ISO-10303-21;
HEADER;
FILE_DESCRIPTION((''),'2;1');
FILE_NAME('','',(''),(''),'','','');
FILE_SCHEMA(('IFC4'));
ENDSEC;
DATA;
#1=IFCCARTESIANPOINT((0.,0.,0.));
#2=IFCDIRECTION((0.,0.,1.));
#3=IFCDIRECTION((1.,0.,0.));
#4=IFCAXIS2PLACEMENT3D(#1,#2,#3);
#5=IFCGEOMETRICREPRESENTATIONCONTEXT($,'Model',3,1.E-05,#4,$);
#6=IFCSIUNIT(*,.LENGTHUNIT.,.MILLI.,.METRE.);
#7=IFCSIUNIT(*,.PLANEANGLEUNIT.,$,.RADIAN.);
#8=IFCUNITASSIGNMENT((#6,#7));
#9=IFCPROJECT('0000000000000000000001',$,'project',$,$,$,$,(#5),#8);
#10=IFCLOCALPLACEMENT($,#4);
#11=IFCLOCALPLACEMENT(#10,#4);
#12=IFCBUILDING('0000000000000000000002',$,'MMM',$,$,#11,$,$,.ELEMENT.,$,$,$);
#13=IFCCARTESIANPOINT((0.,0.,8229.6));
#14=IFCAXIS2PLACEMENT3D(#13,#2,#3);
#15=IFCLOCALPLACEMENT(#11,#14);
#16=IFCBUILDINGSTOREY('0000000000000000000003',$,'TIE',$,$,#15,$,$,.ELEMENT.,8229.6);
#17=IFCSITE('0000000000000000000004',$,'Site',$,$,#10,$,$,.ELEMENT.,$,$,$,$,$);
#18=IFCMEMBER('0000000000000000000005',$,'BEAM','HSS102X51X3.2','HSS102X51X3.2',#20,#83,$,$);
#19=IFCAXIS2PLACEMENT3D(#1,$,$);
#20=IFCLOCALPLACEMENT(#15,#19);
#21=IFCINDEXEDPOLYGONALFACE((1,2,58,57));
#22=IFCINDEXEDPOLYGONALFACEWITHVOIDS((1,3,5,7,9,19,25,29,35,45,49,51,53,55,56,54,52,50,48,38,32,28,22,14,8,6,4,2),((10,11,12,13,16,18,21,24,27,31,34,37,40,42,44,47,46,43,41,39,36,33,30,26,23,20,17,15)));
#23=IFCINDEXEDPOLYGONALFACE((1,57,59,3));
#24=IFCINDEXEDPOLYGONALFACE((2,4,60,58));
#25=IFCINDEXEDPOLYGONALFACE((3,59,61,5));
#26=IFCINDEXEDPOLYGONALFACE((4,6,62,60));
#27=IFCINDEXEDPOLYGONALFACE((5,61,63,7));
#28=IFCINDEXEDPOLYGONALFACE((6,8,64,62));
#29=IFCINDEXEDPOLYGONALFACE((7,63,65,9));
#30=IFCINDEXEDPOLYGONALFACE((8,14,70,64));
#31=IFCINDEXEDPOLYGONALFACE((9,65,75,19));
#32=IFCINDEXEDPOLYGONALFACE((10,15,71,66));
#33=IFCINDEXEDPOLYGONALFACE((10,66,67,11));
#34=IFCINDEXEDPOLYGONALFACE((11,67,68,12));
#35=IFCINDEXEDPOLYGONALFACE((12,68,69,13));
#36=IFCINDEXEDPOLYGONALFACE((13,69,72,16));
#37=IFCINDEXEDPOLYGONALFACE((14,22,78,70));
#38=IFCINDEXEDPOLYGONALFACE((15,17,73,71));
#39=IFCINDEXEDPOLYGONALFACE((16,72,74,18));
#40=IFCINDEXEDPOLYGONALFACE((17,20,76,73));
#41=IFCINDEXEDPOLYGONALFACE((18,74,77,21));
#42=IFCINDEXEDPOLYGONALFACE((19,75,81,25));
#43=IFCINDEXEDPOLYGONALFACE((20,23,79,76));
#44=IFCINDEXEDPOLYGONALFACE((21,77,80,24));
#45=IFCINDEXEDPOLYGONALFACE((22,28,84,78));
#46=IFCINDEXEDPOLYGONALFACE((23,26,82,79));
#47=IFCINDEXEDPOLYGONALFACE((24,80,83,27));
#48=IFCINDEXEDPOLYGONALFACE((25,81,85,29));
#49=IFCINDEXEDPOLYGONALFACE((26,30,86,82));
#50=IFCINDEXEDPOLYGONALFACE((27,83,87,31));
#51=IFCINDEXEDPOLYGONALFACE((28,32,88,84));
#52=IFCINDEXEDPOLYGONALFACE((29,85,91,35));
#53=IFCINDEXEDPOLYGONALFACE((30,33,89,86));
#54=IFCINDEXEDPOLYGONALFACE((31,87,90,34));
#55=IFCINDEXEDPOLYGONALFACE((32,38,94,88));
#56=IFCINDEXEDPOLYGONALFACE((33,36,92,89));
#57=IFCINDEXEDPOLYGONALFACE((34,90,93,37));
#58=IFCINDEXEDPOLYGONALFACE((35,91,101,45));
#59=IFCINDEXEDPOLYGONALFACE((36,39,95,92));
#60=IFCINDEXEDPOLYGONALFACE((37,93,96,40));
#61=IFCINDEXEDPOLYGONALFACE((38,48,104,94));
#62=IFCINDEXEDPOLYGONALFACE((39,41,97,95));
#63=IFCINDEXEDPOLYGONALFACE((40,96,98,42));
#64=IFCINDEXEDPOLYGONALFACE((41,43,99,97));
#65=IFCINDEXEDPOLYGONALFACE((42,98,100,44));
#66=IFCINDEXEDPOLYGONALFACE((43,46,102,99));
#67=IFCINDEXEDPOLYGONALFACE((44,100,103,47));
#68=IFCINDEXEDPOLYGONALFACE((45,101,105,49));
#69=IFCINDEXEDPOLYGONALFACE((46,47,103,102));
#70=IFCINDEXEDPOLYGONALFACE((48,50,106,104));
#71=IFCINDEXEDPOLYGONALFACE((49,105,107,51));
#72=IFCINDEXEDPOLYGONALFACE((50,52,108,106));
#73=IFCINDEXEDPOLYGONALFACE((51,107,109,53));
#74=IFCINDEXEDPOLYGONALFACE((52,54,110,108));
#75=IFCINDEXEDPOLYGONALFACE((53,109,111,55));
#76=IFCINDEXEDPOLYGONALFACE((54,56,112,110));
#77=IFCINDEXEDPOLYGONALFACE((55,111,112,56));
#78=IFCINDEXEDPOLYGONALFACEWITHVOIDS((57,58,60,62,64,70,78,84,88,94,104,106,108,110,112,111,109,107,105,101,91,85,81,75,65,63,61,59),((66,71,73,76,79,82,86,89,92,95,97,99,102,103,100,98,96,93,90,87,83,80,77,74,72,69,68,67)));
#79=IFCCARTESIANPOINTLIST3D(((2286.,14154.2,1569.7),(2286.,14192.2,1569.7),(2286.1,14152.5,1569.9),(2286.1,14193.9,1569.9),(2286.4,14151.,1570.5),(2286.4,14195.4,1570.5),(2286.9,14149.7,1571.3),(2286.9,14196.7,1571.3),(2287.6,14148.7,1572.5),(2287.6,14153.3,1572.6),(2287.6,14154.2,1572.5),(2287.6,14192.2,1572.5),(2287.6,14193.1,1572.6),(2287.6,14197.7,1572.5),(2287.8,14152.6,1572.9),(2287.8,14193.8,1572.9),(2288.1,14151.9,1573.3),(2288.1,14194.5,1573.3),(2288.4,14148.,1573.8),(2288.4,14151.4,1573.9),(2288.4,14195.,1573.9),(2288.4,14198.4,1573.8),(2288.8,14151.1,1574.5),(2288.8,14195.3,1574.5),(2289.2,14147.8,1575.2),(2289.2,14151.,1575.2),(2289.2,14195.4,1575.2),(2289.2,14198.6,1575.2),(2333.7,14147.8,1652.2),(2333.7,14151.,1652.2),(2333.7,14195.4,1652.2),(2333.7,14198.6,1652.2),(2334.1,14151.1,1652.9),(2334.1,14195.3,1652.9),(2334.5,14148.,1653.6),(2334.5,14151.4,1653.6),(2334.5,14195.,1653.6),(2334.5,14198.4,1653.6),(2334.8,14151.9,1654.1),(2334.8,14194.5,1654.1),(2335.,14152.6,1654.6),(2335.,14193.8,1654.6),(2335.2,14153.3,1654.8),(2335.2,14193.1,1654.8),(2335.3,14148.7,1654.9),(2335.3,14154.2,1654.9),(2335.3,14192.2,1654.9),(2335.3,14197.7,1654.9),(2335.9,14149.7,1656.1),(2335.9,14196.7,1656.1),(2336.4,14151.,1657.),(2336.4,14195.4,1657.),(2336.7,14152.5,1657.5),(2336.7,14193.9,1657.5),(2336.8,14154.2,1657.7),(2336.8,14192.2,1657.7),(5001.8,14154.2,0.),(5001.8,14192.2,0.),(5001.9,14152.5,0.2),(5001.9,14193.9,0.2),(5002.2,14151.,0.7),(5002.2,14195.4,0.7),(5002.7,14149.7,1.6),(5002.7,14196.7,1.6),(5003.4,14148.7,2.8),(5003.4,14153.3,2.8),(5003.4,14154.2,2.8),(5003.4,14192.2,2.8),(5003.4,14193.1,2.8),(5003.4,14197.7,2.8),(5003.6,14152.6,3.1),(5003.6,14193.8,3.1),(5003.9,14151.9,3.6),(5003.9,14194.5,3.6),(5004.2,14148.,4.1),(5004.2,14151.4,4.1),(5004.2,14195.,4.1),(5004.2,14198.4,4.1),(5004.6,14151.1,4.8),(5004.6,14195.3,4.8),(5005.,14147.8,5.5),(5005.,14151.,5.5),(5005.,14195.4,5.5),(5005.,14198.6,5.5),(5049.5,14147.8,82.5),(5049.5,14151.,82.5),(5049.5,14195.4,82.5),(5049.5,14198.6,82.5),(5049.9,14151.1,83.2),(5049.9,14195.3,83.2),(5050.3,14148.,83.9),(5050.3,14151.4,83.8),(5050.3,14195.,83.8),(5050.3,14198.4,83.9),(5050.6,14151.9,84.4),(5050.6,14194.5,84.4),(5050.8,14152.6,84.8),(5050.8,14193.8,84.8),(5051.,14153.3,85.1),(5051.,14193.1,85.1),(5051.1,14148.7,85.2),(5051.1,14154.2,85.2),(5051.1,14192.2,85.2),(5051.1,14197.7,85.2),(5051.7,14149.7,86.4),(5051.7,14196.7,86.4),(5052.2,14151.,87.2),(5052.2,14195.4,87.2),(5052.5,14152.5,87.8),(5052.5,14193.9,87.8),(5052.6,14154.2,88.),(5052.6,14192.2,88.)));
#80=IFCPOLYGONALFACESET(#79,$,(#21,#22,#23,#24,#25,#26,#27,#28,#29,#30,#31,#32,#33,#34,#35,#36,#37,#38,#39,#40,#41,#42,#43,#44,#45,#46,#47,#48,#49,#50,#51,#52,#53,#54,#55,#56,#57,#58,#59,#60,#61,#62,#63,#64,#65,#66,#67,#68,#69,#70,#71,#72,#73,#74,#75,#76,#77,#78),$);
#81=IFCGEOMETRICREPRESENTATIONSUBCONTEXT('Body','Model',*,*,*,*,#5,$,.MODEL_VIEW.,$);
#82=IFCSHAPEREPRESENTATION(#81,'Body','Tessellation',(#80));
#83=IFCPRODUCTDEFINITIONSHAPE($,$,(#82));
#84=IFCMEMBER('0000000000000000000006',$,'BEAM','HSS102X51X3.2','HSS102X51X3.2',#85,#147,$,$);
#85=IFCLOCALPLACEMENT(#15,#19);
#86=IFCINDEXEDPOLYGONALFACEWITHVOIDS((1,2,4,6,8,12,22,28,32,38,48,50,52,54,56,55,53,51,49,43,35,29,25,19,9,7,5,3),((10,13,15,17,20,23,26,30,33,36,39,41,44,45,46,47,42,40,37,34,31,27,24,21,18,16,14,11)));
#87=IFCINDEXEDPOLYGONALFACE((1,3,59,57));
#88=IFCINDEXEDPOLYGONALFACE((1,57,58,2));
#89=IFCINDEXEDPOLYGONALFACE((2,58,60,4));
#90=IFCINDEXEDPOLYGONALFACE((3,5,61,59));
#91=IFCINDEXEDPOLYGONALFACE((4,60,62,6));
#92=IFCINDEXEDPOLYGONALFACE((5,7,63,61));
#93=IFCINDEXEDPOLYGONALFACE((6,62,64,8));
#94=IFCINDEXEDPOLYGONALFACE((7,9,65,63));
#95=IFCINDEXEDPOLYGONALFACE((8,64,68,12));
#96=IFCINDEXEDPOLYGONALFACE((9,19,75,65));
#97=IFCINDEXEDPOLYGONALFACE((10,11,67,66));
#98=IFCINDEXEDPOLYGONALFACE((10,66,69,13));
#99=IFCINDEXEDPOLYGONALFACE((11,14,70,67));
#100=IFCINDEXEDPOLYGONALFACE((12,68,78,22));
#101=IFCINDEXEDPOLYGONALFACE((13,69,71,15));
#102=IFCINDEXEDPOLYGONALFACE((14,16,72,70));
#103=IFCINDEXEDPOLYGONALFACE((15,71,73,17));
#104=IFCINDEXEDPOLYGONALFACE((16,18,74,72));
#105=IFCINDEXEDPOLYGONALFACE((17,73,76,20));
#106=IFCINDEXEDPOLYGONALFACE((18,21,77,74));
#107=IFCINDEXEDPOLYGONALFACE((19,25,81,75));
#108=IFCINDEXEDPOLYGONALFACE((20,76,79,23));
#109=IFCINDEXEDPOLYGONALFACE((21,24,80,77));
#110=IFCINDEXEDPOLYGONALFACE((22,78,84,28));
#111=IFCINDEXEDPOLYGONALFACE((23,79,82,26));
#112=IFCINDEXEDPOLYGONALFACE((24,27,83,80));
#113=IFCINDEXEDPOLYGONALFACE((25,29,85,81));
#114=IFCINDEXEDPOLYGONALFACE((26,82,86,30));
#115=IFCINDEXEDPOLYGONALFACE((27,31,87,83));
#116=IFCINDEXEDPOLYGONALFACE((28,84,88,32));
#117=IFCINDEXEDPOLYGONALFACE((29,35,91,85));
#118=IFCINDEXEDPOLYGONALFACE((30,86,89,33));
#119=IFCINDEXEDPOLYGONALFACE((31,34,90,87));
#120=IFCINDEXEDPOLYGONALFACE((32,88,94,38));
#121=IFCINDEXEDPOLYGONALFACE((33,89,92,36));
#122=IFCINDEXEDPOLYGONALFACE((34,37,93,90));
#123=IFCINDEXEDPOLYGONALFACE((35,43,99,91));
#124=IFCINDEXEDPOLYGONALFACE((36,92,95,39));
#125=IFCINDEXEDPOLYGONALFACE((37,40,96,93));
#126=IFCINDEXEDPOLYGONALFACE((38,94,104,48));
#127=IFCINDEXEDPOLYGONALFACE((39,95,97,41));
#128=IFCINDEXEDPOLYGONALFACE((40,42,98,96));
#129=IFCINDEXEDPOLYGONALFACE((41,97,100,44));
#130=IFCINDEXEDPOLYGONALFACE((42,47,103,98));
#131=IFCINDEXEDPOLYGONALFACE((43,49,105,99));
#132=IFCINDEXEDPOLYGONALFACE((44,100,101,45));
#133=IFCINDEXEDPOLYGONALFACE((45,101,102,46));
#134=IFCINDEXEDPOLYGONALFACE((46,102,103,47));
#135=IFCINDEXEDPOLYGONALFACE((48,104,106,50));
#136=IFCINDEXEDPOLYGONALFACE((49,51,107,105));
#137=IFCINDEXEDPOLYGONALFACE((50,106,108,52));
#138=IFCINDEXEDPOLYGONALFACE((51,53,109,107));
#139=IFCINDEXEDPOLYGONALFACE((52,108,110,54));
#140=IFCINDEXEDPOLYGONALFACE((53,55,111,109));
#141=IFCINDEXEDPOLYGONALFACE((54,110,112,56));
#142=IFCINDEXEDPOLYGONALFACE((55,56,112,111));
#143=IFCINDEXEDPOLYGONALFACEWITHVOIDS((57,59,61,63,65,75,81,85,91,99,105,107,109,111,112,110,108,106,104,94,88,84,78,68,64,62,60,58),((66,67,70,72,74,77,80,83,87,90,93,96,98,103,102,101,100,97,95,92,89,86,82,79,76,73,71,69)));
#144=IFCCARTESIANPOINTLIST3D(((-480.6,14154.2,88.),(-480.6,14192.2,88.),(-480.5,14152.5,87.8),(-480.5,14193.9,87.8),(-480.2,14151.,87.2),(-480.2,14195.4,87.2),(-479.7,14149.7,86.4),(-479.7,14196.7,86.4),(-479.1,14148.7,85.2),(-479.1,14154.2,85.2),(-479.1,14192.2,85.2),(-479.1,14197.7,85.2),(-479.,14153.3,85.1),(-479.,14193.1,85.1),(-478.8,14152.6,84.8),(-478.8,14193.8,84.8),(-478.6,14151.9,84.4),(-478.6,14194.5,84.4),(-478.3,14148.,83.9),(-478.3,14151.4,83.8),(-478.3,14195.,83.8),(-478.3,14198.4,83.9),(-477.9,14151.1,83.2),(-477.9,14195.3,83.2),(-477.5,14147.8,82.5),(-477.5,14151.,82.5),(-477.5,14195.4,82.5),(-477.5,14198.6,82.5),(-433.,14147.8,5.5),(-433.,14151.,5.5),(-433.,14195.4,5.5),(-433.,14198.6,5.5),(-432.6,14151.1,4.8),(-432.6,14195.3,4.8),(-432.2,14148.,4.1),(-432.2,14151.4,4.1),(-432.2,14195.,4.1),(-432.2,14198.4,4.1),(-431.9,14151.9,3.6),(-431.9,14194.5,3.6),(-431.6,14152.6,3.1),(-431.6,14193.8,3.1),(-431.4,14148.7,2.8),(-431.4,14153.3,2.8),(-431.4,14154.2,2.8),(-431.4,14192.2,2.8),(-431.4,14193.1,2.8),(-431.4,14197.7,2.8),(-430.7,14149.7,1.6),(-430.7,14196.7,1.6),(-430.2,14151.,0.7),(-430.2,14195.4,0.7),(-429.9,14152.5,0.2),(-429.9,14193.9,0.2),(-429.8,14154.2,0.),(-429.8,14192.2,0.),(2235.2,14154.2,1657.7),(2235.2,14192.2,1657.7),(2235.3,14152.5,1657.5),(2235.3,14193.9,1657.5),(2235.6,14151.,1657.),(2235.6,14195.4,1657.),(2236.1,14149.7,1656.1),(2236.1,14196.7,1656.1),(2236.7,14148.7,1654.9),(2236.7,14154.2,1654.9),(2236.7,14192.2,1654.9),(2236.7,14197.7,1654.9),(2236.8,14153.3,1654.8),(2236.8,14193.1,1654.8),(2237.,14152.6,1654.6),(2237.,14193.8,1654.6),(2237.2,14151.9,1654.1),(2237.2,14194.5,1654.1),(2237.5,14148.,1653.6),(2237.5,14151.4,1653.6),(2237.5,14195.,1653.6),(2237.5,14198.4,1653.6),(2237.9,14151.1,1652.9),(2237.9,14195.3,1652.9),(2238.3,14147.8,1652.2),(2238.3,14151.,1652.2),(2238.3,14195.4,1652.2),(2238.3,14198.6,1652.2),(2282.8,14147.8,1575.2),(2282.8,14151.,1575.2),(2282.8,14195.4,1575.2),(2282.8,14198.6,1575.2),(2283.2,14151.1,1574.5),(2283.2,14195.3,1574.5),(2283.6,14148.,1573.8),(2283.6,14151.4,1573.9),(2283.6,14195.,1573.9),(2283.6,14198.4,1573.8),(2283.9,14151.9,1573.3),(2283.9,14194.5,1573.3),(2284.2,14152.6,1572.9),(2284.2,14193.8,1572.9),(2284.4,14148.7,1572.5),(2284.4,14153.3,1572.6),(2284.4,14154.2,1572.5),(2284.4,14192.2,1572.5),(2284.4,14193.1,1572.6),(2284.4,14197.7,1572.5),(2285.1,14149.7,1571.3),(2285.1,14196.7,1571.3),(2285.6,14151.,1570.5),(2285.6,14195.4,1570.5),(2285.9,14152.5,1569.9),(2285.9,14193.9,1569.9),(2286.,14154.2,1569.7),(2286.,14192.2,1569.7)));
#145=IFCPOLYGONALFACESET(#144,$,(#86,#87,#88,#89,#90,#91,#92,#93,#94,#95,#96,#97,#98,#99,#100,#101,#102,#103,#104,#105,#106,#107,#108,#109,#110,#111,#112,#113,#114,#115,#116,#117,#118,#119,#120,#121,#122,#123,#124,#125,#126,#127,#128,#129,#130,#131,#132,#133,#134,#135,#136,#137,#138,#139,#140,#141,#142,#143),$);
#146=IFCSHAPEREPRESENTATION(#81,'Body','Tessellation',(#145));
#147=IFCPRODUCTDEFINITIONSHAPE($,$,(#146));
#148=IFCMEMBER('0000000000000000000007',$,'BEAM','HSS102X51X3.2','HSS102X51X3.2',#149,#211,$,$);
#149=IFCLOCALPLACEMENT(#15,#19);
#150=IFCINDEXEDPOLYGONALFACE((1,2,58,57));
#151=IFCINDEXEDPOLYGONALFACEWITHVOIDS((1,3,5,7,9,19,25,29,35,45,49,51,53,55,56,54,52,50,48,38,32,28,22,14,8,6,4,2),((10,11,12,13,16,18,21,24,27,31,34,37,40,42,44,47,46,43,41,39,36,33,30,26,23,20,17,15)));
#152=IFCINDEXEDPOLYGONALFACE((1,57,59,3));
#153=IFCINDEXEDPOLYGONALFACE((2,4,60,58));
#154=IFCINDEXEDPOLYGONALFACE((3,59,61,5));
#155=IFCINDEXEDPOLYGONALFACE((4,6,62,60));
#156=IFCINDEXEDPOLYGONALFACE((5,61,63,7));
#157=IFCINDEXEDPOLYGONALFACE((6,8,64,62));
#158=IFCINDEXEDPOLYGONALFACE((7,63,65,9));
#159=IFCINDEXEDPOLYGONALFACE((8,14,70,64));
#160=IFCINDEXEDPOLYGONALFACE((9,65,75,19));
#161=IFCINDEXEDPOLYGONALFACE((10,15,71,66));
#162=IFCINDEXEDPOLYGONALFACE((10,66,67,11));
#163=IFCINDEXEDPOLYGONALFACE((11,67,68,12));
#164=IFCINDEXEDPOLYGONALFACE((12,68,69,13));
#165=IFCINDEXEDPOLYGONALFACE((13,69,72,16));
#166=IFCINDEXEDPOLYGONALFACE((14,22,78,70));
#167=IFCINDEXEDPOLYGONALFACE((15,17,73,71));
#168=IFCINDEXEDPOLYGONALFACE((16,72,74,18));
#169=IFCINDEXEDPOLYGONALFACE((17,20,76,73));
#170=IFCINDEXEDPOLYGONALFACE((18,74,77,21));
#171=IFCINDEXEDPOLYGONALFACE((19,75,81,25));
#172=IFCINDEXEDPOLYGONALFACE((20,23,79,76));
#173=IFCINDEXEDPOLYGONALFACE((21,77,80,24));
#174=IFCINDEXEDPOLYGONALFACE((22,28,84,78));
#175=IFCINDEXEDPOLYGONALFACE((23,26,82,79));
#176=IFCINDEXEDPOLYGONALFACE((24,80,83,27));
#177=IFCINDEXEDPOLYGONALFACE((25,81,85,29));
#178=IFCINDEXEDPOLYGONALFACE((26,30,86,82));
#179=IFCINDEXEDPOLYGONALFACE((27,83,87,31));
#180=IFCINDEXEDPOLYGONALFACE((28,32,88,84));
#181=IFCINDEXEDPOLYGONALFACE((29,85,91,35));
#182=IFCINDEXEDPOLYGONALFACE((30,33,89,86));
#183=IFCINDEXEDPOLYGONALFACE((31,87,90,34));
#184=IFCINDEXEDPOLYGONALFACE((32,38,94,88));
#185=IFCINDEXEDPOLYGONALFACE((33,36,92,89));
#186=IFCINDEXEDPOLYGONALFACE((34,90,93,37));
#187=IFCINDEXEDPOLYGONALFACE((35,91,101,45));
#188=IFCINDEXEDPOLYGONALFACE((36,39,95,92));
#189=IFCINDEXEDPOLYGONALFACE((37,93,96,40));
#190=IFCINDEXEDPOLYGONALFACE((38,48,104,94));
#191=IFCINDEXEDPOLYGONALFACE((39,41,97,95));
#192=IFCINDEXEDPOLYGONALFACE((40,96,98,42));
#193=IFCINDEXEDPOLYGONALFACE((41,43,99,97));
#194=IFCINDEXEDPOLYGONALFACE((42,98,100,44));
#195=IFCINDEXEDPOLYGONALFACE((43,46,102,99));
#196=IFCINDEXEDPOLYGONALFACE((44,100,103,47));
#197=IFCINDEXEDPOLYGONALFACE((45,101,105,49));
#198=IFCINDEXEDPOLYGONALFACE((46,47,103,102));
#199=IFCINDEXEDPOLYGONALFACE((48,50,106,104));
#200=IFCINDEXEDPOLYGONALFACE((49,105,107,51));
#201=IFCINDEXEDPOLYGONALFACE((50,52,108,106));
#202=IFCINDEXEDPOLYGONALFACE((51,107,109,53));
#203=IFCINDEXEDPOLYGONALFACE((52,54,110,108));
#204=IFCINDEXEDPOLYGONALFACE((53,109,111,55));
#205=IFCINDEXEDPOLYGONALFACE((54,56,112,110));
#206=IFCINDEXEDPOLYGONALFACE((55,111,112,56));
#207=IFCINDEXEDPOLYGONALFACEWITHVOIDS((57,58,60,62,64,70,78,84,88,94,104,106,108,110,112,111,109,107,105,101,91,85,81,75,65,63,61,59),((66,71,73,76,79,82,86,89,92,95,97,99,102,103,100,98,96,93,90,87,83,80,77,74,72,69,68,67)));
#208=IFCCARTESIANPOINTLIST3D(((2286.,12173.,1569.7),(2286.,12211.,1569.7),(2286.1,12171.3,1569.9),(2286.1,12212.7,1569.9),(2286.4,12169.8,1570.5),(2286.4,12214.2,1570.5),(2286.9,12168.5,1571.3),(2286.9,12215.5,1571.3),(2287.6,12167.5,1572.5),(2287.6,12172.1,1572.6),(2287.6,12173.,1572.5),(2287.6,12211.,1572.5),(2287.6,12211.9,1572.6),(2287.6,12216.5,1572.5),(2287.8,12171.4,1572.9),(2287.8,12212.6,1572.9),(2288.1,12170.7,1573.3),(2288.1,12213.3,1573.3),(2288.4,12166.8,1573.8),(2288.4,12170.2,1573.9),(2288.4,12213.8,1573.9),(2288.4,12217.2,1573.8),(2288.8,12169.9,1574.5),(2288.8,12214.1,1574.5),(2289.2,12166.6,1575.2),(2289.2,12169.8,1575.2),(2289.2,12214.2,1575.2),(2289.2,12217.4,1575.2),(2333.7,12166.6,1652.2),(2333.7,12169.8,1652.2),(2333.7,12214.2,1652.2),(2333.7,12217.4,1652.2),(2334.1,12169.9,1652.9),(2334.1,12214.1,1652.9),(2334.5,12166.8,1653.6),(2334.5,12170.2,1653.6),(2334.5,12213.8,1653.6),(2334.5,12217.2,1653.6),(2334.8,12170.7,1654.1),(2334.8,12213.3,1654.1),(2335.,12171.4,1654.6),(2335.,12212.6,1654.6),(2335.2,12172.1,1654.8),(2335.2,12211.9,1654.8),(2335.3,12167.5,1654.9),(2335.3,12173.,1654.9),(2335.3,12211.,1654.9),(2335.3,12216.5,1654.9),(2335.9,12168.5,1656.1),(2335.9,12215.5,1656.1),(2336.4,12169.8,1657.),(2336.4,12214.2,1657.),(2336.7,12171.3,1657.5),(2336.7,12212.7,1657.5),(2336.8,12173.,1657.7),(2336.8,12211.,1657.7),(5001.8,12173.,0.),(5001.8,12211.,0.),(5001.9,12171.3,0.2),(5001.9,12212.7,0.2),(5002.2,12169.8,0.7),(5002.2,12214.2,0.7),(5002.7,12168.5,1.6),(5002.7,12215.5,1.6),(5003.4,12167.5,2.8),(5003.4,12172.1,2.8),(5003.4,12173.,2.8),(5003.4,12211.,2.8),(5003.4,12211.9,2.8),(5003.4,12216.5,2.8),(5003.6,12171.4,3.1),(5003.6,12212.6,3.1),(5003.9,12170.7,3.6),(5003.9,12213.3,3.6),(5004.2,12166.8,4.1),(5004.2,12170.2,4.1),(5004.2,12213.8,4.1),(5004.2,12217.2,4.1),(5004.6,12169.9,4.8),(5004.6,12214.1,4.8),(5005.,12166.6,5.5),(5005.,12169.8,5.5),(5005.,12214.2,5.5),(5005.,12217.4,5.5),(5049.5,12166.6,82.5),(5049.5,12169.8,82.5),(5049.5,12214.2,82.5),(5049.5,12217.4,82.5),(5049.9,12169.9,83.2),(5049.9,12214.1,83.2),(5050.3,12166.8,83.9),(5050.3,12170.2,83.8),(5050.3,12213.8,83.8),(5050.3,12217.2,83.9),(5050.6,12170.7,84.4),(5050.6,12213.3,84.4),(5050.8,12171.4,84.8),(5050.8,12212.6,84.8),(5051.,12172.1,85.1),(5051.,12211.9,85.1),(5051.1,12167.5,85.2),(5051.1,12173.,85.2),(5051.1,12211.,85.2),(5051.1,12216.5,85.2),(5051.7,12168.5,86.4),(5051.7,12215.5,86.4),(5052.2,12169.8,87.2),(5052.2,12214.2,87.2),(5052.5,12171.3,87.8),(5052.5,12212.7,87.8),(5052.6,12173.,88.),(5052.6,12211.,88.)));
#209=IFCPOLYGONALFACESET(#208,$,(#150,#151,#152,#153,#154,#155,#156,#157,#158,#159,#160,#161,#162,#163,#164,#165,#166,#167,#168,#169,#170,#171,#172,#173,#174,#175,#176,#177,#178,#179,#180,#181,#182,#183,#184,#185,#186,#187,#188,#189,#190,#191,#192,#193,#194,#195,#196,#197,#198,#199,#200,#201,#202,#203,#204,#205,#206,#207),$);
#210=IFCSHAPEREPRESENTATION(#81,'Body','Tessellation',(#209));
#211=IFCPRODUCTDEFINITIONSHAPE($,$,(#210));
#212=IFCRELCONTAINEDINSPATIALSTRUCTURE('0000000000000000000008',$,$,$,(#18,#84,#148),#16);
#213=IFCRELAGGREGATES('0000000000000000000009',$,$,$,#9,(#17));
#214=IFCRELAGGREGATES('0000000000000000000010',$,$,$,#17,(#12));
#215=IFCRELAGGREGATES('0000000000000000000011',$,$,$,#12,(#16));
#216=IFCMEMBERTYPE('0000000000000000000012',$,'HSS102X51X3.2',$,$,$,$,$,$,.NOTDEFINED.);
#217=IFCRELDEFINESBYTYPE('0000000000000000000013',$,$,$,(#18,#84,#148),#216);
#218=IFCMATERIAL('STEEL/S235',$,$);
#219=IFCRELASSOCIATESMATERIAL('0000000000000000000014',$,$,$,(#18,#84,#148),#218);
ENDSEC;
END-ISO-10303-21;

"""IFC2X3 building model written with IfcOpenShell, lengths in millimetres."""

from ifc_helpers import new_model, si_unit, frame, origin_with_axes, origin_2d_with_axis, place, context, subcontext, project, spatial, hollow_rectangle, extrude, material, type_object, element, save


model = new_model("IFC2X3")

# Units and contexts
model_context = context("Model", 3, precision=1e-05, world=origin_with_axes())
body_context = subcontext(model_context, "Body", "Model", "MODEL_VIEW")
ifc_project = project(units=[si_unit("LENGTHUNIT", "METRE", prefix="MILLI"), si_unit("PLANEANGLEUNIT", "RADIAN")], contexts=[model_context])

# Site, building, storey
site_placement = place(None, origin_with_axes())
site = spatial("IfcSite", under=ifc_project, at=site_placement, Name="Site", CompositionType="ELEMENT")
building_placement = place(site_placement, origin_with_axes())
building = spatial("IfcBuilding", under=site, at=building_placement, Name="MMM", CompositionType="ELEMENT")
storey_placement = place(building_placement, frame((0.0, 0.0, 8229.6), z_axis=(0.0, 0.0, 1.0), x_axis=(1.0, 0.0, 0.0)))
storey = spatial("IfcBuildingStorey", under=building, at=storey_placement, Name="TIE", CompositionType="ELEMENT", Elevation=8229.6)

# Shared definitions
ifc_material = material(Name="STEEL/S235")

# Members
member_type_1 = type_object("IfcMemberType", Name="HSS102X51X3.2", PredefinedType="NOTDEFINED")
for number, where, z_axis, x_axis, name in (
    (1, (2311.4, 14173.2, 1613.7), (0.500422, 0.0, 0.865782), (0.865782, 0.0, -0.500422), "BEAM"),
    (2, (2260.6, 14173.2, 1613.7), (-0.500422, 0.0, 0.865782), (-0.865782, 0.0, -0.500422), "BEAM"),
    (3, (2311.4, 12192.0, 1613.7), (0.500422, 0.0, 0.865782), (0.865782, 0.0, -0.500422), "BEAM"),
):
    element("IfcMember", number, at=place(storey_placement, frame(where, z_axis=z_axis, x_axis=x_axis)), inside=storey, type_object=member_type_1, material=ifc_material, Name=name, Description="HSS102X51X3.2", ObjectType="HSS102X51X3.2", context=body_context, shape_type="SweptSolid", body=[
        extrude(hollow_rectangle(XDim=50.8, YDim=101.6, WallThickness=3.2, InnerFilletRadius=3.2, OuterFilletRadius=6.4, at=origin_2d_with_axis()), frame((3136.8, 0.0, 0.0), z_axis=(-1.0, 0.0, 0.0), x_axis=(0.0, -1.0, 0.0)), (0.0, 0.0, 1.0), 3136.8),
    ])

save(model, "model.ifc")
